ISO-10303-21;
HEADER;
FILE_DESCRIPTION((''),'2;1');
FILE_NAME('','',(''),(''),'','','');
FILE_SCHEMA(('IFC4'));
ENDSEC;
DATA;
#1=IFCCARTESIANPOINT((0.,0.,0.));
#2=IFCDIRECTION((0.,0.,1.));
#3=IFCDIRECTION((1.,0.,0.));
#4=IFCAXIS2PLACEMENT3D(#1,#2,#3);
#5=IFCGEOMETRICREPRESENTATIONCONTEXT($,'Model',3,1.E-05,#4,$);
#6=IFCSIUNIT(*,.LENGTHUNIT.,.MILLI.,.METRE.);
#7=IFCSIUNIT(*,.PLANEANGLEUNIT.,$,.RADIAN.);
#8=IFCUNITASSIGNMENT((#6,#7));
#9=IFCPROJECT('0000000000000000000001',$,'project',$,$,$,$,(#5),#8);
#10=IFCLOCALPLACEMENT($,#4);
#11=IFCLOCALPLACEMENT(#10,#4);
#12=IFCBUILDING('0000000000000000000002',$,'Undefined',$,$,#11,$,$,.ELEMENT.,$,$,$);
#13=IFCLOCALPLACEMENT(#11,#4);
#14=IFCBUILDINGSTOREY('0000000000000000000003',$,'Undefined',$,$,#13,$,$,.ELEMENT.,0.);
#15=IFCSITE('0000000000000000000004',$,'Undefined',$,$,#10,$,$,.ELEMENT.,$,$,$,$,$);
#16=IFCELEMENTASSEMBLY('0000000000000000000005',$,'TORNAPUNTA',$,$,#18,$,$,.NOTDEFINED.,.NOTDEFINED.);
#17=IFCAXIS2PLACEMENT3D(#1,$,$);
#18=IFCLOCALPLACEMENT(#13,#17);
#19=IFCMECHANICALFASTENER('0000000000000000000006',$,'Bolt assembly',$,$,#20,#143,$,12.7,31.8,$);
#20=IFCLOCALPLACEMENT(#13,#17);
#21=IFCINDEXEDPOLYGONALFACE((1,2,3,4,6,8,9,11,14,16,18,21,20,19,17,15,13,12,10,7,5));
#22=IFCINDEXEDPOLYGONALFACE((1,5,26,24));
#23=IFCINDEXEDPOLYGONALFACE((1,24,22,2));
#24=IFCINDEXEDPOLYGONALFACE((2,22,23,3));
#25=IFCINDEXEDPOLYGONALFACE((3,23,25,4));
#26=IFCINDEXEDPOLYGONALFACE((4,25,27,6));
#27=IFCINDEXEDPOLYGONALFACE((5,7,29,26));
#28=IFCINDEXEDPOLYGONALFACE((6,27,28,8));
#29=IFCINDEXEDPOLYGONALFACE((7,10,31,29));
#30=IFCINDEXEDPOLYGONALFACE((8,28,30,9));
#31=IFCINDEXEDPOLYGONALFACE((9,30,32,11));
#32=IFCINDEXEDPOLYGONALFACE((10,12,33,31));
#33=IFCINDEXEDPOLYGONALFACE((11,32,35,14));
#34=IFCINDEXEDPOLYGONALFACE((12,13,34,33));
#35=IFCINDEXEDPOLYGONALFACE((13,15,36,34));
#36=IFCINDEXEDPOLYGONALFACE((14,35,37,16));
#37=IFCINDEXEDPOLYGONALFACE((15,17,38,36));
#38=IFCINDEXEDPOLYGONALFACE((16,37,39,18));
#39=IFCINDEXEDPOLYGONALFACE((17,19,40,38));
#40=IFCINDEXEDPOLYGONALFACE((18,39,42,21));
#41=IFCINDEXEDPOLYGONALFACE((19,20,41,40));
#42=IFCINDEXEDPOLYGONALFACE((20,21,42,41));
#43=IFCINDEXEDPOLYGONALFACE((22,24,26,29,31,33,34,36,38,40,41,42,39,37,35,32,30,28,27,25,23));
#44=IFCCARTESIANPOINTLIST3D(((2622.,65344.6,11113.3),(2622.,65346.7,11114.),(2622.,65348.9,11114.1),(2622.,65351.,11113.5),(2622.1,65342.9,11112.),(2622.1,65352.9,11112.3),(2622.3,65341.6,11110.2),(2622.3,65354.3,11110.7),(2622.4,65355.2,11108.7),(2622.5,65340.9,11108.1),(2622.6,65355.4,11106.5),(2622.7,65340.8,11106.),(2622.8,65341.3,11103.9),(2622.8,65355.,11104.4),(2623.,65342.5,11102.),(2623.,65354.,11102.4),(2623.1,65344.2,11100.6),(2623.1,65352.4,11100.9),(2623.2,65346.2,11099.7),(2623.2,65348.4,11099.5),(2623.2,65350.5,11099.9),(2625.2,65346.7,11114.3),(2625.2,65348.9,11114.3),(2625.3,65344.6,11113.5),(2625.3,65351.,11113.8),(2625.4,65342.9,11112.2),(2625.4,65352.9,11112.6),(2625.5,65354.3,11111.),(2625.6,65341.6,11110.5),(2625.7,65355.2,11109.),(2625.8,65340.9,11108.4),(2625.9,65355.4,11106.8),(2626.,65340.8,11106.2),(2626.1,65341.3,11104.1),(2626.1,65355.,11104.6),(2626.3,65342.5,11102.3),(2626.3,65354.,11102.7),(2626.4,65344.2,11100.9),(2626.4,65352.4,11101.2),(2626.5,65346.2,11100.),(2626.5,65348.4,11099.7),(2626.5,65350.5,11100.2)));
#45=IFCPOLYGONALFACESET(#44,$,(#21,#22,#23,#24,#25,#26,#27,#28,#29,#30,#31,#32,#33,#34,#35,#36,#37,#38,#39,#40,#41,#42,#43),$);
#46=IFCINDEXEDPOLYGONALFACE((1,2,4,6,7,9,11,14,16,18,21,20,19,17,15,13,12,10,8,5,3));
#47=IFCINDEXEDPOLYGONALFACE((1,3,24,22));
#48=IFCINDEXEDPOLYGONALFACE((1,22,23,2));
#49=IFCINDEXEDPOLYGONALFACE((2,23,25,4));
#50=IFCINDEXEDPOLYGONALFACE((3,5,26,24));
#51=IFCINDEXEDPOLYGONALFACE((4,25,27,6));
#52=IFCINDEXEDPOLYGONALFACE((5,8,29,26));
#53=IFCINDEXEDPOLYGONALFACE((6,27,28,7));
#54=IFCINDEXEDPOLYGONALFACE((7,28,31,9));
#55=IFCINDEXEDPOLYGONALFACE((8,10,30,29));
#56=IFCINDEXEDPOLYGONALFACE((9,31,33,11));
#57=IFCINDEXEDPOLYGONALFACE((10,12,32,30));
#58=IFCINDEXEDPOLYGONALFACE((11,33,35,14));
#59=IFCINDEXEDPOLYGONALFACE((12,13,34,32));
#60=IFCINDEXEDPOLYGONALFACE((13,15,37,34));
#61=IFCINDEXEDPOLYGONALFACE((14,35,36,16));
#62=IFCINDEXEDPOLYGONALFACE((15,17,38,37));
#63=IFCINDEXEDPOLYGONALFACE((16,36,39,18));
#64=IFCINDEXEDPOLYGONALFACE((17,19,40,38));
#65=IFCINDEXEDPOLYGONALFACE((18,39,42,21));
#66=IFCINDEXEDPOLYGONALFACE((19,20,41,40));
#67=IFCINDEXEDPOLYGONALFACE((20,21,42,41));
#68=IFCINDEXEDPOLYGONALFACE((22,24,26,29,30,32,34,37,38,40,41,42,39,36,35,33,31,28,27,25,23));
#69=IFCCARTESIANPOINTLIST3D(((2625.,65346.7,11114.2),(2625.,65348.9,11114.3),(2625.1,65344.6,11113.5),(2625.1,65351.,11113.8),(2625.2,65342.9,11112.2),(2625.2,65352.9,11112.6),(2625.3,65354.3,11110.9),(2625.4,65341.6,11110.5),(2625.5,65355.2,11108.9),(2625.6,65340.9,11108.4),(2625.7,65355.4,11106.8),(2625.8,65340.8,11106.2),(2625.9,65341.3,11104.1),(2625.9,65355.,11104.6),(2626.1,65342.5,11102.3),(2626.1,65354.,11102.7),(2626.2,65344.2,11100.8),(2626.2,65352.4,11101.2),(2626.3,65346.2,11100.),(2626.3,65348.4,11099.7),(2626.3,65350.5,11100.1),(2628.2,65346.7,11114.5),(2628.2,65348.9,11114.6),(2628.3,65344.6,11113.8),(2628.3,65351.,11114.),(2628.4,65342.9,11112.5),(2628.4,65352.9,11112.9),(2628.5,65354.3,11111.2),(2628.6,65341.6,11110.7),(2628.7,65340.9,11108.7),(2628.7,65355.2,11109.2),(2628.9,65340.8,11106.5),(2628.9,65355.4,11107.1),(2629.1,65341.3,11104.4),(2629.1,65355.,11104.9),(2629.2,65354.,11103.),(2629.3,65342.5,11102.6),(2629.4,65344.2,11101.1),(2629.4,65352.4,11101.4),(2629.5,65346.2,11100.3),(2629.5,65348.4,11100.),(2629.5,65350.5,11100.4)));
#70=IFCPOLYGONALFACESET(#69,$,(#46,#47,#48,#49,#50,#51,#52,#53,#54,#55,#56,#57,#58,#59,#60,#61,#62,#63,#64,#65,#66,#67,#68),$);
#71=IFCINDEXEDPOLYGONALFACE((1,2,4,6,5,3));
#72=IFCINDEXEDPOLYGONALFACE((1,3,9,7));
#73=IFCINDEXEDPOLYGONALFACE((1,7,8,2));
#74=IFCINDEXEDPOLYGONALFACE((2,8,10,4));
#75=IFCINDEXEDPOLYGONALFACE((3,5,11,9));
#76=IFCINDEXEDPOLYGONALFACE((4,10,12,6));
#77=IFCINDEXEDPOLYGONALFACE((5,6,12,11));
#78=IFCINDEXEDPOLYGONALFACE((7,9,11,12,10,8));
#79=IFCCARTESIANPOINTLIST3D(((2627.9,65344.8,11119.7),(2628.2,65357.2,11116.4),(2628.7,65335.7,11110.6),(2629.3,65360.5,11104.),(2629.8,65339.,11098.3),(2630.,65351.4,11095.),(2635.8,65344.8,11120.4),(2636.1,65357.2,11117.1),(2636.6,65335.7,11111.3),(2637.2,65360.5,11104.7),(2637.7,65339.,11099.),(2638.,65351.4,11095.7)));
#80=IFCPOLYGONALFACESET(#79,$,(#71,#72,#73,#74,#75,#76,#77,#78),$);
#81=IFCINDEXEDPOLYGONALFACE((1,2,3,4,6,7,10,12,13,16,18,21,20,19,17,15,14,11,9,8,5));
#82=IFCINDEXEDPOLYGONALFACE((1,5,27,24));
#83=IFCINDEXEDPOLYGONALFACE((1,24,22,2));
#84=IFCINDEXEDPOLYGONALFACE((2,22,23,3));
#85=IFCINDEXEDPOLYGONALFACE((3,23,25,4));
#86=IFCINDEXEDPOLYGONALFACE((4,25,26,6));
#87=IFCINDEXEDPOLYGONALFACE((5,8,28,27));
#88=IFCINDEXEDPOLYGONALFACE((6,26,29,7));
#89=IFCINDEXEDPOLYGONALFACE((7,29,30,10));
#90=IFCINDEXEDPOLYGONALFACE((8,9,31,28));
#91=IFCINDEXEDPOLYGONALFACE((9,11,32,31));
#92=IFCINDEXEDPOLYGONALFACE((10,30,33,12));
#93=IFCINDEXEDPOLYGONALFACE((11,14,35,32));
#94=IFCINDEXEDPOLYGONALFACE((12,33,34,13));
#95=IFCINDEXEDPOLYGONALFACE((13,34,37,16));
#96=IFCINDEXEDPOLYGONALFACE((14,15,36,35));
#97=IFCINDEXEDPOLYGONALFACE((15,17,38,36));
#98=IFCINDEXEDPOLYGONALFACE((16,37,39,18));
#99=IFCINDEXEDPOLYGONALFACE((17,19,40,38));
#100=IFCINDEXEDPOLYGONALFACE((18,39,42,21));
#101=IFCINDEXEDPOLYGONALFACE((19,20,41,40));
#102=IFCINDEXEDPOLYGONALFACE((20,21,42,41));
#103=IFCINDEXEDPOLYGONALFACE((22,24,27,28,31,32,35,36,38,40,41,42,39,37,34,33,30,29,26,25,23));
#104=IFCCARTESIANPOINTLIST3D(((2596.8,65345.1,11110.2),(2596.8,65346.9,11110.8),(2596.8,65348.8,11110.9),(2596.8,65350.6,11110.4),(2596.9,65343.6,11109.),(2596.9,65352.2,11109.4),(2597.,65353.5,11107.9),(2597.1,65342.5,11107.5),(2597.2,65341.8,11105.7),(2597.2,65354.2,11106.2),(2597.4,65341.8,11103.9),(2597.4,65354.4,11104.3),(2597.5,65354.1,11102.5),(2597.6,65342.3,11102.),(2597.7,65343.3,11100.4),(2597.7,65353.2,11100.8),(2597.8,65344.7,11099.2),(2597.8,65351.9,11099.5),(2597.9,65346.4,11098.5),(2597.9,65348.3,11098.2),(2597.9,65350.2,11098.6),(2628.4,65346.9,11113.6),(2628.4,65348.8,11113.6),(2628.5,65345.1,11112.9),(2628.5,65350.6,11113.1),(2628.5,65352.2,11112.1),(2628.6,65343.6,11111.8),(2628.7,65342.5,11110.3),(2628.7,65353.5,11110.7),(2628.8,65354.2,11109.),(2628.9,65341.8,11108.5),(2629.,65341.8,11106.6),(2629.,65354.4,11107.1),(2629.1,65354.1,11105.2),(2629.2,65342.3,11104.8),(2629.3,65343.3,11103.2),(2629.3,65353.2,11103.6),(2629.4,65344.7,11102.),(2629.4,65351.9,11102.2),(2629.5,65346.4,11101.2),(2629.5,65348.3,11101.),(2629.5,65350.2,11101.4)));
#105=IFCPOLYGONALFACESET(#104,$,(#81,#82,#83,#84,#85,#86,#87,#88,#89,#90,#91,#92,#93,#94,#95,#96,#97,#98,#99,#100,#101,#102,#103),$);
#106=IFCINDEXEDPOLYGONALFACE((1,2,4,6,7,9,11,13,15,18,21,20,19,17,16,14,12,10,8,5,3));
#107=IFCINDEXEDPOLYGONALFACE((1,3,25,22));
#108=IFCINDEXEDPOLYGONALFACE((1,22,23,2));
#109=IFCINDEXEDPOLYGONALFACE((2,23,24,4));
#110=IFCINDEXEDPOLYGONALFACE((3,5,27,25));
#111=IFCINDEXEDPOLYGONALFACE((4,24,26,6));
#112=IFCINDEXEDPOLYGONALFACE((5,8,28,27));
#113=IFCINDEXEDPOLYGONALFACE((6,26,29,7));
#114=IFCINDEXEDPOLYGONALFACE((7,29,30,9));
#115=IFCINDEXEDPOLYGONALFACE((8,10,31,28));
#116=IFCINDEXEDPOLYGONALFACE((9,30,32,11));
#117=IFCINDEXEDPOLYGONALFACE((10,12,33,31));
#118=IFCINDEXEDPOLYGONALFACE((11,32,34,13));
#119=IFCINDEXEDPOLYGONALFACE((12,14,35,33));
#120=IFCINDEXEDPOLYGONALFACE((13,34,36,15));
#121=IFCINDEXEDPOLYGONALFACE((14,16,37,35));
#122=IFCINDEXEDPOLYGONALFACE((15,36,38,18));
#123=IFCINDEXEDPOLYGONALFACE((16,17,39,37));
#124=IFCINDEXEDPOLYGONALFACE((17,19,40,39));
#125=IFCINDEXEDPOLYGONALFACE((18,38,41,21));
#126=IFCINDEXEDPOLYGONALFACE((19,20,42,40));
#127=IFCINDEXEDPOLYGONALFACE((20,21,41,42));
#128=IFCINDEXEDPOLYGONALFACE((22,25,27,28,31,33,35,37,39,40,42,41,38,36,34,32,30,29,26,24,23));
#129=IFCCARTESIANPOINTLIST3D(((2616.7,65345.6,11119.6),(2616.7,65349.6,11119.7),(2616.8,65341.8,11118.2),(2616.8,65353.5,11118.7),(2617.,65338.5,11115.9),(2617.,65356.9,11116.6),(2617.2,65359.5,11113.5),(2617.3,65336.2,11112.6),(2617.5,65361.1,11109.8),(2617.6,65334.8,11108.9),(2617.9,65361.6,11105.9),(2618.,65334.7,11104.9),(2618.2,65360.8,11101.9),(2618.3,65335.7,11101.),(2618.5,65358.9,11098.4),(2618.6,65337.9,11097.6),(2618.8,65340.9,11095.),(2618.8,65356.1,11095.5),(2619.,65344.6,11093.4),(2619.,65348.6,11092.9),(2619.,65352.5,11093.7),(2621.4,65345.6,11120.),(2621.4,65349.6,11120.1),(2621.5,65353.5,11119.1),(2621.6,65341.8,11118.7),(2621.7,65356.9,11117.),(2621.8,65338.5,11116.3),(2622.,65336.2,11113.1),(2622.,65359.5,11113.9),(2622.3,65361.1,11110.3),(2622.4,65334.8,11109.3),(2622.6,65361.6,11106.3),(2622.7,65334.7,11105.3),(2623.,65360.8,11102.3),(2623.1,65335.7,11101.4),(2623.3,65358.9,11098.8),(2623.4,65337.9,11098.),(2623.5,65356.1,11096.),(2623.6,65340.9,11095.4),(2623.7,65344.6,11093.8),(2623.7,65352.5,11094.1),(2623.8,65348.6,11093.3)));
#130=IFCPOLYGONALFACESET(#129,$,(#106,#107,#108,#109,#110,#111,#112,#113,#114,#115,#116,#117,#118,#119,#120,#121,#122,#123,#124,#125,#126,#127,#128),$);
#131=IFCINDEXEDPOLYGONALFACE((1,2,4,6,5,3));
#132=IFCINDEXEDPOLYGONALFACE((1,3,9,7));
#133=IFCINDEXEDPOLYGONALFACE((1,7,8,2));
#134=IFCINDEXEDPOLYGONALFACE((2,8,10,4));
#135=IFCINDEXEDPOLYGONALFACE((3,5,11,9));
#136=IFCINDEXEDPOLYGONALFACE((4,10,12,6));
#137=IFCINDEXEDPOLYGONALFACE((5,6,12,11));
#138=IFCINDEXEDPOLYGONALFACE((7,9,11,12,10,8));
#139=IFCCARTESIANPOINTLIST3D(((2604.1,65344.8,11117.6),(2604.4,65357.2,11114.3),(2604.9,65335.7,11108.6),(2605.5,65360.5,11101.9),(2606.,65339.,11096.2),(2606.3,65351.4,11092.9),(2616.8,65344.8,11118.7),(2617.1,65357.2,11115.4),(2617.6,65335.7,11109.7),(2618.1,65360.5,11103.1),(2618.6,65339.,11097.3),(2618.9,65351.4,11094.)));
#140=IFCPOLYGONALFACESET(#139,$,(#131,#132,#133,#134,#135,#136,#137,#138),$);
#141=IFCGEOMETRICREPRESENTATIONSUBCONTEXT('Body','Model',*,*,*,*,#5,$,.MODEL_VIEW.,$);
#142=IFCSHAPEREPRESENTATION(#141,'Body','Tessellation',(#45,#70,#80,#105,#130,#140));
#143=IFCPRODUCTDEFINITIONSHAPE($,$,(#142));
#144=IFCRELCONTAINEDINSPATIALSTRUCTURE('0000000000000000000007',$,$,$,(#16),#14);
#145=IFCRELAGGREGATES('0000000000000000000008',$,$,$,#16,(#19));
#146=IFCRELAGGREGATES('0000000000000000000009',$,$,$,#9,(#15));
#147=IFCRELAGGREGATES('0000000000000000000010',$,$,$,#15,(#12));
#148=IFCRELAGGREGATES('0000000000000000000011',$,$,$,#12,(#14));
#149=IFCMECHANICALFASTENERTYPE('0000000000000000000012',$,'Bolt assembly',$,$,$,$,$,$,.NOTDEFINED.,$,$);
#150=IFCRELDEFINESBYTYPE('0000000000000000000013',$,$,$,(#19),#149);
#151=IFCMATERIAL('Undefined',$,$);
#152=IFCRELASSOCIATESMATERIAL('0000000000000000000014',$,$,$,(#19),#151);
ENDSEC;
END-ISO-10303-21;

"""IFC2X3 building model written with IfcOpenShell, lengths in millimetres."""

from ifc_helpers import new_model, si_unit, frame, origin_with_axes, origin_2d_with_axis, place, context, subcontext, project, spatial, polyline, circle, outline, extrude, source, transform, mapped, material, type_object, element, aggregate, save


model = new_model("IFC2X3")

# Units and contexts
model_context = context("Model", 3, precision=1e-05, world=origin_with_axes())
body_context = subcontext(model_context, "Body", "Model", "MODEL_VIEW")
ifc_project = project(units=[si_unit("LENGTHUNIT", "METRE", prefix="MILLI"), si_unit("PLANEANGLEUNIT", "RADIAN")], contexts=[model_context])

# Site, building, storey
site_placement = place(None, origin_with_axes())
site = spatial("IfcSite", under=ifc_project, at=site_placement, Name="Undefined", CompositionType="ELEMENT")
building_placement = place(site_placement, origin_with_axes())
building = spatial("IfcBuilding", under=site, at=building_placement, Name="Undefined", CompositionType="ELEMENT")
storey_placement = place(building_placement, origin_with_axes())
storey = spatial("IfcBuildingStorey", under=building, at=storey_placement, Name="Undefined", CompositionType="ELEMENT", Elevation=0.0)

# Element assembly
assembly_1_placement = place(storey_placement, origin_with_axes())
assembly_1 = element("IfcElementAssembly", 1, at=assembly_1_placement, inside=storey, Name="TORNAPUNTA", AssemblyPlace="NOTDEFINED", PredefinedType="NOTDEFINED")

# Mechanical fastener
ifc_material_1 = material(Name="Undefined")
mechanical_fastener_type = type_object("IfcMechanicalFastenerType", Name="Bolt assembly")
shared_shape_1 = source(origin_with_axes(), body_context, "Body", "SweptSolid", [
    extrude(circle(Radius=7.3, at=origin_2d_with_axis()), frame((0.0, -0.1, 0.0), z_axis=(0.0, 1.0, 0.0), x_axis=(1.0, 0.0, 0.0)), (0.0, 0.0, 1.0), 3.3),
    extrude(circle(Radius=7.3, at=origin_2d_with_axis()), frame((0.0, -3.1, 0.0), z_axis=(0.0, 1.0, 0.0), x_axis=(1.0, 0.0, 0.0)), (0.0, 0.0, 1.0), 3.2),
    extrude(outline(polyline([(11.1, -6.4), (11.1, 6.4), (0.0, 12.8), (-11.1, 6.4), (-11.1, -6.4), (0.0, -12.8), (11.1, -6.4)])), frame((0.0, -11.1, 0.0), z_axis=(0.0, 1.0, 0.0), x_axis=(1.0, 0.0, 0.0)), (0.0, 0.0, 1.0), 7.9),
    extrude(circle(Radius=6.3, at=origin_2d_with_axis()), frame((0.0, -3.2, 0.0), z_axis=(0.0, 1.0, 0.0), x_axis=(1.0, 0.0, 0.0)), (0.0, 0.0, 1.0), 31.8),
    extrude(circle(Radius=13.5, at=origin_2d_with_axis()), frame((0.0, 3.2, 0.0), z_axis=(0.0, 1.0, 0.0), x_axis=(1.0, 0.0, 0.0)), (0.0, 0.0, 1.0), 4.8),
    extrude(outline(polyline([(11.1, -6.4), (11.1, 6.4), (0.0, 12.8), (-11.1, 6.4), (-11.1, -6.4), (0.0, -12.8), (11.1, -6.4)])), frame((0.0, 8.0, 0.0), z_axis=(0.0, 1.0, 0.0), x_axis=(1.0, 0.0, 0.0)), (0.0, 0.0, 1.0), 12.7),
])
mechanical_fastener_1_placement = place(assembly_1_placement, frame((2625.8, 65348.1, 11107.1), z_axis=(0.061628, -0.707107, -0.704416), x_axis=(-0.061628, -0.707107, 0.704416)))
mechanical_fastener_1 = element("IfcMechanicalFastener", 2, at=mechanical_fastener_1_placement, type_object=mechanical_fastener_type, material=ifc_material_1, Name="Bolt assembly", NominalDiameter=12.7, NominalLength=31.8, context=body_context, shape_type="MappedRepresentation", body=[
    mapped(shared_shape_1, transform((0.0, 0.0, 0.0))),
])
aggregate(assembly_1, [mechanical_fastener_1])

save(model, "model.ifc")
